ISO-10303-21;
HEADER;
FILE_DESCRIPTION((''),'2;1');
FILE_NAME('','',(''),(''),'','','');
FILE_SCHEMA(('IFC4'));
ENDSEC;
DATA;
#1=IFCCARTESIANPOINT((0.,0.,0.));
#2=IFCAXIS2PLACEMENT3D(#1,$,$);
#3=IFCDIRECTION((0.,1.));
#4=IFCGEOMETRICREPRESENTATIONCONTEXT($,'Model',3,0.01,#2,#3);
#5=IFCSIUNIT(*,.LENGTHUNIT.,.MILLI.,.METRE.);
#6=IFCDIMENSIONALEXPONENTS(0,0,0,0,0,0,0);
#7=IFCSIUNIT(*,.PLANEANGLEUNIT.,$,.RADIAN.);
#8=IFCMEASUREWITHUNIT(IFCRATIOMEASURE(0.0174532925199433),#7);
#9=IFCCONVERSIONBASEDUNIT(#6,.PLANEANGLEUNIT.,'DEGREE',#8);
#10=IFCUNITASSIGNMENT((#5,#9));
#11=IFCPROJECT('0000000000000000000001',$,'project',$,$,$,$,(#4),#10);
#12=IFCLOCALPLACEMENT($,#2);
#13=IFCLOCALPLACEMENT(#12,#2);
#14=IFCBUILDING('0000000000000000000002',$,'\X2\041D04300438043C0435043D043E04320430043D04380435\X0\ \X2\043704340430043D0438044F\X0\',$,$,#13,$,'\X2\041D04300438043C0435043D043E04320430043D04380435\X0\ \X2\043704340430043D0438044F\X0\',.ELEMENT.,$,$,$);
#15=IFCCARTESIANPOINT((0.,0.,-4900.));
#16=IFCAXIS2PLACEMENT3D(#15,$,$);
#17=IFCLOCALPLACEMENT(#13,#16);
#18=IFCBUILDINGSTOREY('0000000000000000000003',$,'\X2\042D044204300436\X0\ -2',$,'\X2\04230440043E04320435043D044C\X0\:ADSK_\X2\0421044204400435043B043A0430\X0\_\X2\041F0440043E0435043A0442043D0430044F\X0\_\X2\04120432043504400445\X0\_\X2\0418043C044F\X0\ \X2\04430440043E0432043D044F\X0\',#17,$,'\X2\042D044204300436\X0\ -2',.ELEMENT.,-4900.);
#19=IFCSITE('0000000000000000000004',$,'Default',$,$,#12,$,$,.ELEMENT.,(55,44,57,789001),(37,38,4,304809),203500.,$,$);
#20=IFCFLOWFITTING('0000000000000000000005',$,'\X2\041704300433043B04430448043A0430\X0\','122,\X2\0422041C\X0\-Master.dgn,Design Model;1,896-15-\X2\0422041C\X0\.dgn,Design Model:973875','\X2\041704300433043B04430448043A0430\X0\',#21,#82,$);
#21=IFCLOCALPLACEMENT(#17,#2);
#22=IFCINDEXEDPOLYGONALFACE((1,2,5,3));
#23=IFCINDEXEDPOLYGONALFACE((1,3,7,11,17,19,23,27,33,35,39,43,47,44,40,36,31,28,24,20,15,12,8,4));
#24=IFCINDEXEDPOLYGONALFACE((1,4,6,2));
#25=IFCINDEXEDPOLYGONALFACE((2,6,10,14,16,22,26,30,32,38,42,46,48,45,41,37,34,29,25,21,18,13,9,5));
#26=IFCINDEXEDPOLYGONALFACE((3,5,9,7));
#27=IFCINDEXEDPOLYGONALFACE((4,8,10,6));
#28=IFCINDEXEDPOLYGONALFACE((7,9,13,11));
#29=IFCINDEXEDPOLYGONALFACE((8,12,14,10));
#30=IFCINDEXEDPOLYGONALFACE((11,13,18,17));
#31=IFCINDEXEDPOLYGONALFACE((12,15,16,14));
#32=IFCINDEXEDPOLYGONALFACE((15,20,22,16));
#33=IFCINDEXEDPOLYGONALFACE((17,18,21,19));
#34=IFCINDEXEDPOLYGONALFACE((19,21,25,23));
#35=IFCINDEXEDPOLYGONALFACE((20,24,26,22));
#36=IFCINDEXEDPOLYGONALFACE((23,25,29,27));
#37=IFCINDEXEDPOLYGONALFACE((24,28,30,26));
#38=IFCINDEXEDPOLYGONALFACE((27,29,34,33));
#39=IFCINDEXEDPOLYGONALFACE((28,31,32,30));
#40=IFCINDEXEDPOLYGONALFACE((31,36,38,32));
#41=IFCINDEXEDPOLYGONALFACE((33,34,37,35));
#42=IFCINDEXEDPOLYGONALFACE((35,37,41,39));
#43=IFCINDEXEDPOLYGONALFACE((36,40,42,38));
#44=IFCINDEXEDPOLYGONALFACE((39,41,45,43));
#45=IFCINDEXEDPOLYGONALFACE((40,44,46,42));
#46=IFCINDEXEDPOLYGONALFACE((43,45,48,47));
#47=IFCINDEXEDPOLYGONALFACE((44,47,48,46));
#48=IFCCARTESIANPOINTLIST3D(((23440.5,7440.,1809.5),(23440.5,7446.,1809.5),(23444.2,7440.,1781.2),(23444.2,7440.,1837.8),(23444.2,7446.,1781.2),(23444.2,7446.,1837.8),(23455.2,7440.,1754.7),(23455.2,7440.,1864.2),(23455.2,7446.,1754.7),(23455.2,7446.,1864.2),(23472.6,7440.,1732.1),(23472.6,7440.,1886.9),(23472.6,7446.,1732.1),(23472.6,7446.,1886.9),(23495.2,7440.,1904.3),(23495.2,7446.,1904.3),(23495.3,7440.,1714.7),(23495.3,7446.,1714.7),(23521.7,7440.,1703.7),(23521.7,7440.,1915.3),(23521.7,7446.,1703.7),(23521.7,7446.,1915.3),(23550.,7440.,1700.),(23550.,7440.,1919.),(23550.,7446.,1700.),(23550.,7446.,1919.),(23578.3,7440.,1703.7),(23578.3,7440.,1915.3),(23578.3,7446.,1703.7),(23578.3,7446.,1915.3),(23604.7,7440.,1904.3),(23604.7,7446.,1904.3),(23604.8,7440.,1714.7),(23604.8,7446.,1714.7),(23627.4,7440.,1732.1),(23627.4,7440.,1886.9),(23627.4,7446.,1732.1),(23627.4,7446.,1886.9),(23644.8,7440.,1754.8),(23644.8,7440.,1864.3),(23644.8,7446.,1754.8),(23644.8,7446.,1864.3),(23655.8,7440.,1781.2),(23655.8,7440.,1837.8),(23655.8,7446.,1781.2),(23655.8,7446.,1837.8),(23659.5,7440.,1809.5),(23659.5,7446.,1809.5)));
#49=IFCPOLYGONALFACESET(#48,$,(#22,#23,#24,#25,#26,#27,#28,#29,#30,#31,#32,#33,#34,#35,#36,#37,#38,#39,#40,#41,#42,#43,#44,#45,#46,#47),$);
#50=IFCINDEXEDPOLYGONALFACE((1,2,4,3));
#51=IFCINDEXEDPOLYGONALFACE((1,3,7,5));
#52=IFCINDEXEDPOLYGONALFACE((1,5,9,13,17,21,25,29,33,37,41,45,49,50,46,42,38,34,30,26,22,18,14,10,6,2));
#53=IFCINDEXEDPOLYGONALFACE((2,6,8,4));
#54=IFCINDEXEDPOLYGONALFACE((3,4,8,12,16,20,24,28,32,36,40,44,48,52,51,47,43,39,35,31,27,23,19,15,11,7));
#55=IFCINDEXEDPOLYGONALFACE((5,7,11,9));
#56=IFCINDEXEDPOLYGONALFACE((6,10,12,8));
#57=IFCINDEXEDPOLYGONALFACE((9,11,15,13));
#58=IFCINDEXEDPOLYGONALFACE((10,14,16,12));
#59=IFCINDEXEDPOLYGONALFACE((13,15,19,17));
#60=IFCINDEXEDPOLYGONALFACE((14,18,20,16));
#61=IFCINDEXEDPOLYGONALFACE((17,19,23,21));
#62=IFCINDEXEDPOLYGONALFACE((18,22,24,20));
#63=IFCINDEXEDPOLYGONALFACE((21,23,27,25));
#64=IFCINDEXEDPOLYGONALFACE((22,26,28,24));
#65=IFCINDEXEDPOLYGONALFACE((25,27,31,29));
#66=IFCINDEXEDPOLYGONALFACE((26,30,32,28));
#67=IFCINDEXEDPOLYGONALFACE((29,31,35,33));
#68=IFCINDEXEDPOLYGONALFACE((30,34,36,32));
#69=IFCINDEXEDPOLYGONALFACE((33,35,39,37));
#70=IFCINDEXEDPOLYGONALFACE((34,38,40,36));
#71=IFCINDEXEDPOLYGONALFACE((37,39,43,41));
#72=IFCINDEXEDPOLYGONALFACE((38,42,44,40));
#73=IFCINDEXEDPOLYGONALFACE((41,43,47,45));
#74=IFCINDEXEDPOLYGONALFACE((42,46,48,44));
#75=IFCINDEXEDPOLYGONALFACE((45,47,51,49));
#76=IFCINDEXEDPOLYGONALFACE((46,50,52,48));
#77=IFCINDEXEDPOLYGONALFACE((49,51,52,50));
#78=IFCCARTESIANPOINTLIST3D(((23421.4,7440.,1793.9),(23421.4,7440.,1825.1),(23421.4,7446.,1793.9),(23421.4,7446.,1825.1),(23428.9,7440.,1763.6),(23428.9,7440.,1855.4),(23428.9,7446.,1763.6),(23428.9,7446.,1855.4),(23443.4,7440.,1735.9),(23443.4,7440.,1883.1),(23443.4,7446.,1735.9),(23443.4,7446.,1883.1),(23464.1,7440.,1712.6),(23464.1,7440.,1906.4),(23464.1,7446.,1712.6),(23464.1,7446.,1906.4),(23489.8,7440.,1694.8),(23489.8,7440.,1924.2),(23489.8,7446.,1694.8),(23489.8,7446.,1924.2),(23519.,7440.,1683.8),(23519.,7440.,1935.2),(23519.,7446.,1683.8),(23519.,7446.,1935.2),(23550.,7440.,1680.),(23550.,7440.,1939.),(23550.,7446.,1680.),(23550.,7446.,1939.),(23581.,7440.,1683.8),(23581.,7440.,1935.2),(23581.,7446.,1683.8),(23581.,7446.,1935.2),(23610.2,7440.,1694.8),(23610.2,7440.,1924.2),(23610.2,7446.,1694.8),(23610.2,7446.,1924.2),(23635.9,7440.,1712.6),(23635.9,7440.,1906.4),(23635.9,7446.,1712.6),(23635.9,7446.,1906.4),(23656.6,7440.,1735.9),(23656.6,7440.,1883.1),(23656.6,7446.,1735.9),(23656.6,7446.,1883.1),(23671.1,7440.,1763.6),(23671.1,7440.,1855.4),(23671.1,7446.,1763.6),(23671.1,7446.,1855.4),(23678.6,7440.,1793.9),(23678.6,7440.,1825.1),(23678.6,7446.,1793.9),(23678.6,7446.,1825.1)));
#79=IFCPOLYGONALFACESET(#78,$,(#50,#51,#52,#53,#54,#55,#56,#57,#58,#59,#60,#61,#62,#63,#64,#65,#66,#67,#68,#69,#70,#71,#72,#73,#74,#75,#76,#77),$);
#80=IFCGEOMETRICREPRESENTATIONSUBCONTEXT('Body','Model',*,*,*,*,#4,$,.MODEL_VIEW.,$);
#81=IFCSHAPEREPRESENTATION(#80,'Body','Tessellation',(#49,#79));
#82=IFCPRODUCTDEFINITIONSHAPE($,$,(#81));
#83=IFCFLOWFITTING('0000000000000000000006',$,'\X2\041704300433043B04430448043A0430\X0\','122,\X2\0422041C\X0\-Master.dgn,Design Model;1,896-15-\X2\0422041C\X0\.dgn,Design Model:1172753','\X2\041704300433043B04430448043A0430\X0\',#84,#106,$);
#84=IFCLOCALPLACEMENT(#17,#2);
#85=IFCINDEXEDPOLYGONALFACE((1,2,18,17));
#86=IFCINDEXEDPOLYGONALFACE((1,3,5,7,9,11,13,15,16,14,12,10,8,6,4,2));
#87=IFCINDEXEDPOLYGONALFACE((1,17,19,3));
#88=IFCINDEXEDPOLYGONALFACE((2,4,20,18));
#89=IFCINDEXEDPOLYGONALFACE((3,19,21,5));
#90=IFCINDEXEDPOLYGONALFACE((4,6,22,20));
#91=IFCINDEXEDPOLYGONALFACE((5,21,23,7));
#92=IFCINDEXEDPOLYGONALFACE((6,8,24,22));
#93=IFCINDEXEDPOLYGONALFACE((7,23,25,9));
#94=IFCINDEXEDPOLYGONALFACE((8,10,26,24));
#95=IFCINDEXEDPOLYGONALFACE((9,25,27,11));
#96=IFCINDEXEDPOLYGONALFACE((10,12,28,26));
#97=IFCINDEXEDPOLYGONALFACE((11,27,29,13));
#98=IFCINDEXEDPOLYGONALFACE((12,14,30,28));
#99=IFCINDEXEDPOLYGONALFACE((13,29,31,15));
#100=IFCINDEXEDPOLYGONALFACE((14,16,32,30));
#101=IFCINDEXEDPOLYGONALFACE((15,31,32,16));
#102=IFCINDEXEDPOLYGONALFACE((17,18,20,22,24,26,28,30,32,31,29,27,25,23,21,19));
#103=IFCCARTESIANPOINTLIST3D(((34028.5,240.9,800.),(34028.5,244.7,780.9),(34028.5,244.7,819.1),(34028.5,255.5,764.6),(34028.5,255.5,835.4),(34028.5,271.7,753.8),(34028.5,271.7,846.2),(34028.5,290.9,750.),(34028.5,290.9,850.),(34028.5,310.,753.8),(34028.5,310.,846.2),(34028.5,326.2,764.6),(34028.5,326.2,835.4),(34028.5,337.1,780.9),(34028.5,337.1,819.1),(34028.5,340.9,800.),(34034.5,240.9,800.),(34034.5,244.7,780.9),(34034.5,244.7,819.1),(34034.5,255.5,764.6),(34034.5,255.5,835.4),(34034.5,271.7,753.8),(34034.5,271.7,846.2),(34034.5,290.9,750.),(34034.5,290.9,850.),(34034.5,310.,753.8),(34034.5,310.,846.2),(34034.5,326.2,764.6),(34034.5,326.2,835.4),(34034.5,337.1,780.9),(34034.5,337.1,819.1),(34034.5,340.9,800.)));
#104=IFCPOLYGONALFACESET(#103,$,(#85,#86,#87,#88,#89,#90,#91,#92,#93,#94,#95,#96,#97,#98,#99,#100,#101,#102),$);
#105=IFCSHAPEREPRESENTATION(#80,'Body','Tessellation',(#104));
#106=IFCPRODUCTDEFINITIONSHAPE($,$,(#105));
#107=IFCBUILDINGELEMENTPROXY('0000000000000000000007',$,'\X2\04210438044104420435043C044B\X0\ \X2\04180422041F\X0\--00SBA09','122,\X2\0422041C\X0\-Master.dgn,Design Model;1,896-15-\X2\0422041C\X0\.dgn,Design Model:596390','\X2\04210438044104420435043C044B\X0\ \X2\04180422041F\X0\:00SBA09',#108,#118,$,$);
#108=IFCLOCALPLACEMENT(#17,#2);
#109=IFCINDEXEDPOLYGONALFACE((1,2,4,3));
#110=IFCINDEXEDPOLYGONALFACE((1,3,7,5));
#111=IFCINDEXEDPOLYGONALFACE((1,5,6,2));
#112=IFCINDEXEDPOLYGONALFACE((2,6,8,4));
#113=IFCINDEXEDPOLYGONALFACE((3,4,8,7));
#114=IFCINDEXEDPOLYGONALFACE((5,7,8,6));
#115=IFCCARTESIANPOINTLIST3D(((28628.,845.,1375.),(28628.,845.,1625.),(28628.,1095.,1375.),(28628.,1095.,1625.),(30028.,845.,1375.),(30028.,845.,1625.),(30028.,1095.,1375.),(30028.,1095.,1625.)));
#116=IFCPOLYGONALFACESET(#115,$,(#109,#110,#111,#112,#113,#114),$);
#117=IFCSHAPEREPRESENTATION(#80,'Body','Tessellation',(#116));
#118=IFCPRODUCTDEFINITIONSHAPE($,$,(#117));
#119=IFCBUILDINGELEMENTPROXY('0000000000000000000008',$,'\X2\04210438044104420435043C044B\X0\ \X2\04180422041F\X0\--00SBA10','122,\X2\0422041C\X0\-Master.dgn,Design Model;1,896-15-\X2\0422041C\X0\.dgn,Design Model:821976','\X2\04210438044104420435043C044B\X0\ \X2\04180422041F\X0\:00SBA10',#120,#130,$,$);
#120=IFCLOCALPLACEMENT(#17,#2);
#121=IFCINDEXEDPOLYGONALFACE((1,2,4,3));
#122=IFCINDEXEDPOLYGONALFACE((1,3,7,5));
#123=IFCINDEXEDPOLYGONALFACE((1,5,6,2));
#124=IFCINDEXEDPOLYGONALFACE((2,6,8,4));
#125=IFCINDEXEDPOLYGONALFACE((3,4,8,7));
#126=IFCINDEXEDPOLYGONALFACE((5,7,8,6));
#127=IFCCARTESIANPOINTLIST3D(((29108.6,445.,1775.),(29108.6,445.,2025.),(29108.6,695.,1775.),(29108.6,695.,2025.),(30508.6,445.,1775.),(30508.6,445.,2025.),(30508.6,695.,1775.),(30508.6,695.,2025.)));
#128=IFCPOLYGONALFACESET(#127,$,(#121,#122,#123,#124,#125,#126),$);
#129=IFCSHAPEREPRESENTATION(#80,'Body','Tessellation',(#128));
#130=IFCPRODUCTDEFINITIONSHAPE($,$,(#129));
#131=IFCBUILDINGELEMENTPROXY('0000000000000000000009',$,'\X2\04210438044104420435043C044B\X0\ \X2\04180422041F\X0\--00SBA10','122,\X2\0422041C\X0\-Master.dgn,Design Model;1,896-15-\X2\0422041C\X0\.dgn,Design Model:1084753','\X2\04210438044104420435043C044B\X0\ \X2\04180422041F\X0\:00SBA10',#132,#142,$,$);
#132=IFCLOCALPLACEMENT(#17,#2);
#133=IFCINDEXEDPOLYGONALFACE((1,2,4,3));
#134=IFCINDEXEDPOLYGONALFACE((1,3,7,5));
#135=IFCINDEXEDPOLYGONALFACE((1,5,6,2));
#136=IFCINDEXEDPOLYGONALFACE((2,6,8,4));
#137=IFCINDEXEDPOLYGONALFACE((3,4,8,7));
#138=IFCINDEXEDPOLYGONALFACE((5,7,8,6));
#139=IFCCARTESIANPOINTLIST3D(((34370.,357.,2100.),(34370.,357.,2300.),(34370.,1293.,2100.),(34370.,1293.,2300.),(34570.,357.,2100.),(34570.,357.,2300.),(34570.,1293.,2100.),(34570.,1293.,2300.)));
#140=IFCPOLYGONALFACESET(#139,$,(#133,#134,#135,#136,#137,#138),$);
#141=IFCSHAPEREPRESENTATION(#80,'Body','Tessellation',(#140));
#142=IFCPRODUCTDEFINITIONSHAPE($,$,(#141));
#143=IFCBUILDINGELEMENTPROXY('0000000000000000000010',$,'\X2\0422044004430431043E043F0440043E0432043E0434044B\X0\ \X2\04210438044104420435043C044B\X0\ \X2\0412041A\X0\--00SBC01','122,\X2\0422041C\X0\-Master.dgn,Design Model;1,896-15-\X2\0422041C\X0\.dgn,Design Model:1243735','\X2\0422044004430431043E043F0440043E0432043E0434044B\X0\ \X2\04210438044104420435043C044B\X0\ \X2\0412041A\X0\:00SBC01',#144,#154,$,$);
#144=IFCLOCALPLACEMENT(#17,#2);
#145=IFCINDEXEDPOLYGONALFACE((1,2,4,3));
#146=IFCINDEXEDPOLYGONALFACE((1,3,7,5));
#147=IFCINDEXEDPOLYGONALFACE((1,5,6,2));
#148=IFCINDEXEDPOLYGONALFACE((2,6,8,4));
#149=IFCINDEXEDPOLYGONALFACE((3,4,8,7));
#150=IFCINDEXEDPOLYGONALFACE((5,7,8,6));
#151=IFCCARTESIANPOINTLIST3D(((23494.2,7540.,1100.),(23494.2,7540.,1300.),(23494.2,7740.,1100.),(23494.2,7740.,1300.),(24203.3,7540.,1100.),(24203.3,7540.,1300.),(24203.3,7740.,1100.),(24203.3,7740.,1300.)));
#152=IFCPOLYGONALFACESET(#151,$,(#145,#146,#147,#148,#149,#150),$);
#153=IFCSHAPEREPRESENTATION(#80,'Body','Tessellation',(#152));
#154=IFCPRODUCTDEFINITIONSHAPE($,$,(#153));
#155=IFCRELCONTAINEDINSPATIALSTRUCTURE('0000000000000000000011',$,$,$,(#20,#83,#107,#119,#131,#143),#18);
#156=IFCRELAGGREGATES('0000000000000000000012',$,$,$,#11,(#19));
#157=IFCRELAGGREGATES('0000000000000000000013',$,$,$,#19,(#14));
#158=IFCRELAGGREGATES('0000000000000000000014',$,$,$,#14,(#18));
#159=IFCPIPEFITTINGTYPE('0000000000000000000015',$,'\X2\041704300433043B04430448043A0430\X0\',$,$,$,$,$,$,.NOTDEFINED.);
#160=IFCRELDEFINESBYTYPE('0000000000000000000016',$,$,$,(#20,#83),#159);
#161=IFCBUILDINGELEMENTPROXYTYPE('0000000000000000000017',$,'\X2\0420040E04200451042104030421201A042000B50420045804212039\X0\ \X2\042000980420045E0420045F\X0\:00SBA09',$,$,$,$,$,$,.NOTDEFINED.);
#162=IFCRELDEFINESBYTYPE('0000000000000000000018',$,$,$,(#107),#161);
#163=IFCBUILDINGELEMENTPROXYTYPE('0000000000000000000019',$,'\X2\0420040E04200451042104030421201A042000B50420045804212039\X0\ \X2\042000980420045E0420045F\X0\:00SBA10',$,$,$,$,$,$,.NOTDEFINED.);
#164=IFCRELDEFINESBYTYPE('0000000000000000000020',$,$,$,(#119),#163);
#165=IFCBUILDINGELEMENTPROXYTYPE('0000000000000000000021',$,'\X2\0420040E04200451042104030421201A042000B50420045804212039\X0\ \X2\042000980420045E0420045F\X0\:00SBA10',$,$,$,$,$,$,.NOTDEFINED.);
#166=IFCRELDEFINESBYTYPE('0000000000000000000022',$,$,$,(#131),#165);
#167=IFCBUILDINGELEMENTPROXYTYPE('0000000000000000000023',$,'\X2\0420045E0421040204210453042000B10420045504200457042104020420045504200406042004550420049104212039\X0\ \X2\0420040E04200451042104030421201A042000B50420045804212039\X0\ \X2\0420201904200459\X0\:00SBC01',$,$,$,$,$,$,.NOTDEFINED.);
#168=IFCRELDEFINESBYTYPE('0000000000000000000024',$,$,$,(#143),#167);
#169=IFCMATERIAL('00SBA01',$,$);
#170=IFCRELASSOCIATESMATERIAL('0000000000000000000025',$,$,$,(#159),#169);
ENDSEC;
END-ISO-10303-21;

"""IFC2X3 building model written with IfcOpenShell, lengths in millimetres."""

from ifc_helpers import new_model, entity, si_unit, converted_unit, direction, frame, origin, origin_2d_with_axis, place, context, subcontext, project, spatial, polyline, rectangle, outline, extrude, material, type_object, element, save


model = new_model("IFC2X3")

# Units and contexts
model_context = context("Model", 3, precision=0.01, world=origin(), true_north=direction((0.0, 1.0)))
body_context = subcontext(model_context, "Body", "Model", "MODEL_VIEW")
ifc_project = project(units=[si_unit("LENGTHUNIT", "METRE", prefix="MILLI"), converted_unit("PLANEANGLEUNIT", "DEGREE", entity("IfcRatioMeasure", 0.0174532925199433), si_unit("PLANEANGLEUNIT", "RADIAN"), dimensions=[0, 0, 0, 0, 0, 0, 0])], contexts=[model_context])

# Site, building, storey
site_placement = place(None, origin())
site = spatial("IfcSite", under=ifc_project, at=site_placement, Name="Default", CompositionType="ELEMENT", RefLatitude=(55, 44, 57, 789001), RefLongitude=(37, 38, 4, 304809), RefElevation=203500.0)
building_placement = place(site_placement, origin())
building = spatial("IfcBuilding", under=site, at=building_placement, Name="Наименование здания", LongName="Наименование здания", CompositionType="ELEMENT")
storey_placement = place(building_placement, frame((0.0, 0.0, -4900.0)))
storey = spatial("IfcBuildingStorey", under=building, at=storey_placement, Name="Этаж -2", ObjectType="Уровень:ADSK_Стрелка_Проектная_Вверх_Имя уровня", LongName="Этаж -2", CompositionType="ELEMENT", Elevation=-4900.0)

# Flow fittings
ifc_material_1 = material(Name="00SBA01")
pipe_fitting_type_1 = type_object("IfcPipeFittingType", Name="Заглушка", PredefinedType="NOTDEFINED", material=ifc_material_1)
flow_fitting_1_placement = place(storey_placement, frame((23421.4, 7440.0, 1680.0)))
element("IfcFlowFitting", 1, at=flow_fitting_1_placement, inside=storey, type_object=pipe_fitting_type_1, Name="Заглушка", Description="122,ТМ-Master.dgn,Design Model;1,896-15-ТМ.dgn,Design Model:973875", ObjectType="Заглушка", context=body_context, shape_type="SweptSolid", body=[
    extrude(outline(polyline([(-14.3, -108.6), (14.3, -108.6), (41.9, -101.2), (66.7, -86.9), (86.9, -66.7), (101.2, -41.9), (108.6, -14.3), (108.6, 14.3), (101.2, 41.9), (86.9, 66.7), (66.7, 86.9), (41.9, 101.2), (14.3, 108.6), (-14.3, 108.6), (-41.9, 101.2), (-66.7, 86.9), (-86.9, 66.7), (-101.2, 41.9), (-108.6, 14.3), (-108.6, -14.3), (-101.2, -41.9), (-86.9, -66.7), (-66.7, -86.9), (-41.9, -101.2), (-14.3, -108.6)])), frame((128.6, 0.0, 129.5), z_axis=(0.0, 1.0, 0.0), x_axis=(0.991445, 0.0, -0.130526)), (0.0, 0.0, 1.0), 6.0),
    extrude(outline(polyline([(-15.6, -128.6), (15.6, -128.6), (45.9, -121.1), (73.6, -106.6), (96.9, -85.9), (114.7, -60.2), (125.7, -31.0), (129.5, 0.0), (125.7, 31.0), (114.7, 60.2), (96.9, 85.9), (73.6, 106.6), (45.9, 121.1), (15.6, 128.6), (-15.6, 128.6), (-45.9, 121.1), (-73.6, 106.6), (-96.9, 85.9), (-114.7, 60.2), (-125.7, 31.0), (-129.5, 0.0), (-125.7, -31.0), (-114.7, -60.2), (-96.9, -85.9), (-73.6, -106.6), (-45.9, -121.1), (-15.6, -128.6)])), frame((128.6, 0.0, 129.5), z_axis=(0.0, 1.0, 0.0), x_axis=(0.992709, 0.0, -0.120537)), (0.0, 0.0, 1.0), 6.0),
])
flow_fitting_2_placement = place(storey_placement, frame((34028.5, 240.9, 750.0)))
element("IfcFlowFitting", 2, at=flow_fitting_2_placement, inside=storey, type_object=pipe_fitting_type_1, Name="Заглушка", Description="122,ТМ-Master.dgn,Design Model;1,896-15-ТМ.dgn,Design Model:1172753", ObjectType="Заглушка", context=body_context, shape_type="SweptSolid", body=[
    extrude(outline(polyline([(-9.8, -49.0), (9.8, -49.0), (27.8, -41.6), (41.6, -27.8), (49.0, -9.8), (49.0, 9.8), (41.6, 27.8), (27.8, 41.6), (9.8, 49.0), (-9.8, 49.0), (-27.8, 41.6), (-41.6, 27.8), (-49.0, 9.8), (-49.0, -9.8), (-41.6, -27.8), (-27.8, -41.6), (-9.8, -49.0)])), frame((0.0, 50.0, 50.0), z_axis=(1.0, 0.0, 0.0), x_axis=(0.0, -0.980785, -0.19509)), (0.0, 0.0, 1.0), 6.0),
])

# Building element proxies
building_element_proxy_type_1 = type_object("IfcBuildingElementProxyType", Name="РЎРёСЃС‚РµРјС‹ Р\u0098РўРџ:00SBA09", PredefinedType="NOTDEFINED")
proxy_1_placement = place(storey_placement, frame((28628.0, 845.0, 1375.0)))
element("IfcBuildingElementProxy", 3, at=proxy_1_placement, inside=storey, type_object=building_element_proxy_type_1, Name="Системы ИТП--00SBA09", Description="122,ТМ-Master.dgn,Design Model;1,896-15-ТМ.dgn,Design Model:596390", ObjectType="Системы ИТП:00SBA09", context=body_context, shape_type="SweptSolid", body=[
    extrude(rectangle(XDim=250.0, YDim=1400.0, at=origin_2d_with_axis()), frame((700.0, 125.0, 0.0), z_axis=(0.0, 0.0, 1.0), x_axis=(0.0, -1.0, 0.0)), (0.0, 0.0, 1.0), 250.0),
])
building_element_proxy_type_2 = type_object("IfcBuildingElementProxyType", Name="РЎРёСЃС‚РµРјС‹ Р\u0098РўРџ:00SBA10", PredefinedType="NOTDEFINED")
proxy_2_placement = place(storey_placement, frame((29108.6, 445.0, 1775.0)))
element("IfcBuildingElementProxy", 4, at=proxy_2_placement, inside=storey, type_object=building_element_proxy_type_2, Name="Системы ИТП--00SBA10", Description="122,ТМ-Master.dgn,Design Model;1,896-15-ТМ.dgn,Design Model:821976", ObjectType="Системы ИТП:00SBA10", context=body_context, shape_type="SweptSolid", body=[
    extrude(rectangle(XDim=250.0, YDim=1400.0, at=origin_2d_with_axis()), frame((700.0, 125.0, 0.0), z_axis=(0.0, 0.0, 1.0), x_axis=(0.0, -1.0, 0.0)), (0.0, 0.0, 1.0), 250.0),
])
building_element_proxy_type_3 = type_object("IfcBuildingElementProxyType", Name="РЎРёСЃС‚РµРјС‹ Р\u0098РўРџ:00SBA10", PredefinedType="NOTDEFINED")
proxy_3_placement = place(storey_placement, frame((34370.0, 357.0, 2100.0)))
element("IfcBuildingElementProxy", 5, at=proxy_3_placement, inside=storey, type_object=building_element_proxy_type_3, Name="Системы ИТП--00SBA10", Description="122,ТМ-Master.dgn,Design Model;1,896-15-ТМ.dgn,Design Model:1084753", ObjectType="Системы ИТП:00SBA10", context=body_context, shape_type="SweptSolid", body=[
    extrude(rectangle(XDim=200.0, YDim=936.0, at=origin_2d_with_axis()), frame((100.0, 468.0, 0.0), z_axis=(0.0, 0.0, 1.0), x_axis=(-1.0, 0.0, 0.0)), (0.0, 0.0, 1.0), 200.0),
])
building_element_proxy_type_4 = type_object("IfcBuildingElementProxyType", Name="РўСЂСѓР±РѕРїСЂРѕРІРѕРґС‹ РЎРёСЃС‚РµРјС‹ Р’Рљ:00SBC01", PredefinedType="NOTDEFINED")
proxy_4_placement = place(storey_placement, frame((23494.2, 7540.0, 1100.0)))
element("IfcBuildingElementProxy", 6, at=proxy_4_placement, inside=storey, type_object=building_element_proxy_type_4, Name="Трубопроводы Системы ВК--00SBC01", Description="122,ТМ-Master.dgn,Design Model;1,896-15-ТМ.dgn,Design Model:1243735", ObjectType="Трубопроводы Системы ВК:00SBC01", context=body_context, shape_type="SweptSolid", body=[
    extrude(rectangle(XDim=709.1, YDim=200.0, at=origin_2d_with_axis()), frame((354.6, 100.0, 0.0)), (0.0, 0.0, 1.0), 200.0),
])

save(model, "model.ifc")
